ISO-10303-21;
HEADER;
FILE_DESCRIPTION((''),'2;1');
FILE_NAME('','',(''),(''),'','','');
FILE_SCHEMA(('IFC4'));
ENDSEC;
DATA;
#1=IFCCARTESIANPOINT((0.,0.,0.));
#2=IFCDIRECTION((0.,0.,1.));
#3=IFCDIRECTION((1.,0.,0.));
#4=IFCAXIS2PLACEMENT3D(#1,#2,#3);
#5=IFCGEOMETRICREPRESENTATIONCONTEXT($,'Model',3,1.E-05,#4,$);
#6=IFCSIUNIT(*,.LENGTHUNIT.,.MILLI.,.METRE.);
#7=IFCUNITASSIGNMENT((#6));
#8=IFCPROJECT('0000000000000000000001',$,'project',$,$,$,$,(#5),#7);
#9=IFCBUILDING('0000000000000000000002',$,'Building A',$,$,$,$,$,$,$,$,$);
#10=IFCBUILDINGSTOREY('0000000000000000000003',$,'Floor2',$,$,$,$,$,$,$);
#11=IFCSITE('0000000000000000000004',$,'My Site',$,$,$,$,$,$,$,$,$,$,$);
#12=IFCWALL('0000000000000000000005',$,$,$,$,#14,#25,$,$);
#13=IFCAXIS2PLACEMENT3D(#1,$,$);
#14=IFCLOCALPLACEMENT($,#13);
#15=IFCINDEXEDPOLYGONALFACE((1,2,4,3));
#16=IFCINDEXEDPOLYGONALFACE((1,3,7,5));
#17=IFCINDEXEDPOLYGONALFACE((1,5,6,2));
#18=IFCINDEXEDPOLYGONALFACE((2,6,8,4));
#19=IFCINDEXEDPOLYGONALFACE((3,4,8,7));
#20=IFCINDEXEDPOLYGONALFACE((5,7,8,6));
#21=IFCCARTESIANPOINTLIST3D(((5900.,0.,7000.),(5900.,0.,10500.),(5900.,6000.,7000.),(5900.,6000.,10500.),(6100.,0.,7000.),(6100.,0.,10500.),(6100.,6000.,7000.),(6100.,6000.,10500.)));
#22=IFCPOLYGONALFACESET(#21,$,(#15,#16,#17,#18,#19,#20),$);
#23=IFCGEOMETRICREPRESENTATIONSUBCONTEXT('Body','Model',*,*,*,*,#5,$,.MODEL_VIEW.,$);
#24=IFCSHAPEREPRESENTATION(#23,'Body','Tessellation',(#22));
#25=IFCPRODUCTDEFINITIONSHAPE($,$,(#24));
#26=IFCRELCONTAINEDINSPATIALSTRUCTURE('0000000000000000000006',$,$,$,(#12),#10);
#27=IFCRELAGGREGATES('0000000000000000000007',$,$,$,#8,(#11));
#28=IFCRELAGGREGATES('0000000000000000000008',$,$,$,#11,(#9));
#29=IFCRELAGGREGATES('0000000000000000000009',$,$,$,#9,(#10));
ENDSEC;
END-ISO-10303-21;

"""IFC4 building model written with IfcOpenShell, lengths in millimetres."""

from ifc_helpers import new_model, si_unit, frame, origin_with_axes, place, context, subcontext, project, spatial, indexed_curve, outline, extrude, element, save


model = new_model("IFC4")

# Units and contexts
model_context = context("Model", 3, precision=1e-05, world=origin_with_axes())
body_context = subcontext(model_context, "Body", "Model", "MODEL_VIEW")
ifc_project = project(units=[si_unit("LENGTHUNIT", "METRE", prefix="MILLI")], contexts=[model_context])

# Site, building, storey
site = spatial("IfcSite", under=ifc_project, Name="My Site")
building = spatial("IfcBuilding", under=site, Name="Building A")
storey = spatial("IfcBuildingStorey", under=building, Name="Floor2")

# Wall
wall_placement = place(None, frame((6100.0, 0.0, 7000.0), z_axis=(0.0, 0.0, 1.0), x_axis=(0.0, 1.0, 0.0)))
element("IfcWall", 1, at=wall_placement, inside=storey, context=body_context, shape_type="SweptSolid", body=[
    extrude(outline(indexed_curve([(0.0, 0.0), (0.0, 200.0), (6000.0, 200.0), (6000.0, 0.0), (0.0, 0.0)], self_intersect=False)), origin_with_axes(), (0.0, 0.0, 1.0), 3500.0),
])

save(model, "model.ifc")
